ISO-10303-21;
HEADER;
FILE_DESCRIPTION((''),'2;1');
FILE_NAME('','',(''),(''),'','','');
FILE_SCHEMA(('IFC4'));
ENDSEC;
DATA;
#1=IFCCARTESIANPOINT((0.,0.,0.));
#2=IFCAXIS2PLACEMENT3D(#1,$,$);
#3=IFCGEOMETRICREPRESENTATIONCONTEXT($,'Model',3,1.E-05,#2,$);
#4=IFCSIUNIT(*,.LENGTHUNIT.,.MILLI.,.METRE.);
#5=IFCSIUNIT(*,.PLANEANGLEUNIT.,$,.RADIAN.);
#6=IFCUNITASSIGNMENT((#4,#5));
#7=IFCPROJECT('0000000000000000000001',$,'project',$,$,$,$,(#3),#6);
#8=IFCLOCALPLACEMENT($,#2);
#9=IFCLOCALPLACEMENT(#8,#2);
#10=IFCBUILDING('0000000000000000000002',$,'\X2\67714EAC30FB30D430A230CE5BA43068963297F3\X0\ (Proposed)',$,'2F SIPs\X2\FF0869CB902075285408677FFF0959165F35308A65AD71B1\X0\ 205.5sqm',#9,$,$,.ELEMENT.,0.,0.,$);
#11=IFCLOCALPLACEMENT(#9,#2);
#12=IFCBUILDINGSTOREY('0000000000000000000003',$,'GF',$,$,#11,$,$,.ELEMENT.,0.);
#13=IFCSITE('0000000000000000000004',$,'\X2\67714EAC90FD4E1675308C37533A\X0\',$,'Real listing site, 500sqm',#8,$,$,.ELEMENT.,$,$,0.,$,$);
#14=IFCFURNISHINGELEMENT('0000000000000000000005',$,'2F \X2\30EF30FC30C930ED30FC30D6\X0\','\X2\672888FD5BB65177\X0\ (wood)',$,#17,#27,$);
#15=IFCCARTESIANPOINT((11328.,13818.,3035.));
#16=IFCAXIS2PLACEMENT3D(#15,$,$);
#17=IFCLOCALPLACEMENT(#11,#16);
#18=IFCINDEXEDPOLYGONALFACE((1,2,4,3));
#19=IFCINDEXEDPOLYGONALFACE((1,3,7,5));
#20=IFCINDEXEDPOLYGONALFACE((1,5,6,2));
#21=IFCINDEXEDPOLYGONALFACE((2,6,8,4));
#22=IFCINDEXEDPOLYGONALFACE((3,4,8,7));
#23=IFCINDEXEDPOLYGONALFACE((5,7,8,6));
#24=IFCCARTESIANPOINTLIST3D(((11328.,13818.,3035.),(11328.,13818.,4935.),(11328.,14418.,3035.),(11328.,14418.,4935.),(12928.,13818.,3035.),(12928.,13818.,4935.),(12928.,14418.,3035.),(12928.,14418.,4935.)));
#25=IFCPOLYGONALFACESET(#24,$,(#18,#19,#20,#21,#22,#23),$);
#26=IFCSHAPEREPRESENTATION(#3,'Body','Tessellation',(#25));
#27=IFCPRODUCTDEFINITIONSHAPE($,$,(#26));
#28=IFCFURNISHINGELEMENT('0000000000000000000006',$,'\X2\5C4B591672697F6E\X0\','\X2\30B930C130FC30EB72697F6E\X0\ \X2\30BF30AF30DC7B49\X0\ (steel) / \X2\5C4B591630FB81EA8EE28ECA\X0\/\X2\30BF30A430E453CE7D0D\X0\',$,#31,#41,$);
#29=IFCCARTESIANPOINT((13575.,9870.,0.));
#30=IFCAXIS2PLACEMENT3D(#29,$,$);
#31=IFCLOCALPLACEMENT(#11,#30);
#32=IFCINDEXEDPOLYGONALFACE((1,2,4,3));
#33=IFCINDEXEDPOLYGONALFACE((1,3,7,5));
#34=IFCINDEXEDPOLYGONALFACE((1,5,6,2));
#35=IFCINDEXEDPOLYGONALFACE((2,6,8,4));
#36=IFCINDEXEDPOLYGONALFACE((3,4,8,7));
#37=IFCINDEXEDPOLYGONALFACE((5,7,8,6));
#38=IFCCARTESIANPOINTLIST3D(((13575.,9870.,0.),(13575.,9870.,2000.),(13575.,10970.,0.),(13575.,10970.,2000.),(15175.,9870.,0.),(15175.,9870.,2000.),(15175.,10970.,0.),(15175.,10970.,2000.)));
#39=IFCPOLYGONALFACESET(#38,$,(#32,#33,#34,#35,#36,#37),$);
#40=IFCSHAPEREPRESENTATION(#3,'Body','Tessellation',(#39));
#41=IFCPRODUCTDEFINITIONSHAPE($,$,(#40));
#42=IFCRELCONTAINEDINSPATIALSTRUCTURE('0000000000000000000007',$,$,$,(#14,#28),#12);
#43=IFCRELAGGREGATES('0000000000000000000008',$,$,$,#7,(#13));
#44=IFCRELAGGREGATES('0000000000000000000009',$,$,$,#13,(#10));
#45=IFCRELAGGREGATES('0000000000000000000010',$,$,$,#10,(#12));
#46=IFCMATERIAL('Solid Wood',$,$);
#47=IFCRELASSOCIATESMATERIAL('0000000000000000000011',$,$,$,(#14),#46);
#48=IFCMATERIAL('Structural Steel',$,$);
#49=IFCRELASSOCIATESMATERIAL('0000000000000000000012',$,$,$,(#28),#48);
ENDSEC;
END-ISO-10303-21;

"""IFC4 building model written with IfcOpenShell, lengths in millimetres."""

from ifc_helpers import new_model, si_unit, frame, frame_2d, origin, place, context, project, spatial, rectangle, extrude, material, element, save


model = new_model("IFC4")

# Units and contexts
model_context = context("Model", 3, precision=1e-05, world=origin())
ifc_project = project(units=[si_unit("LENGTHUNIT", "METRE", prefix="MILLI"), si_unit("PLANEANGLEUNIT", "RADIAN")], contexts=[model_context])

# Site, building, storey
site_placement = place(None, origin())
site = spatial("IfcSite", under=ifc_project, at=site_placement, Name="東京都世田谷区", ObjectType="Real listing site, 500sqm", CompositionType="ELEMENT", RefElevation=0.0)
building_placement = place(site_placement, origin())
building = spatial("IfcBuilding", under=site, at=building_placement, Name="東京・ピアノ室と防音 (Proposed)", ObjectType="2F SIPs（構造用合板）外張り断熱 205.5sqm", CompositionType="ELEMENT", ElevationOfRefHeight=0.0, ElevationOfTerrain=0.0)
storey_placement = place(building_placement, origin())
storey = spatial("IfcBuildingStorey", under=building, at=storey_placement, Name="GF", CompositionType="ELEMENT", Elevation=0.0)

# Shared definitions
ifc_material_1 = material(Name="Solid Wood")

# Shared definitions
ifc_material_2 = material(Name="Structural Steel")

# Furnishing elements
furnishing_1_placement = place(storey_placement, frame((11328.0, 13818.0, 3035.0)))
element("IfcFurnishingElement", 1, at=furnishing_1_placement, inside=storey, material=ifc_material_1, Name="2F ワードローブ", Description="木製家具 (wood)", context=model_context, shape_type="SweptSolid", body=[
    extrude(rectangle(XDim=1600.0, YDim=600.0, at=frame_2d((800.0, 300.0))), frame((11328.0, 13818.0, 3035.0)), (0.0, 0.0, 1.0), 1900.0),
])
furnishing_2_placement = place(storey_placement, frame((13575.0, 9870.0, 0.0)))
element("IfcFurnishingElement", 2, at=furnishing_2_placement, inside=storey, material=ifc_material_2, Name="屋外物置", Description="スチール物置 タクボ等 (steel) / 屋外・自転車/タイヤ収納", context=model_context, shape_type="SweptSolid", body=[
    extrude(rectangle(XDim=1600.0, YDim=1100.0, at=frame_2d((800.0, 550.0))), frame((13575.0, 9870.0, 0.0)), (0.0, 0.0, 1.0), 2000.0),
])

save(model, "model.ifc")
